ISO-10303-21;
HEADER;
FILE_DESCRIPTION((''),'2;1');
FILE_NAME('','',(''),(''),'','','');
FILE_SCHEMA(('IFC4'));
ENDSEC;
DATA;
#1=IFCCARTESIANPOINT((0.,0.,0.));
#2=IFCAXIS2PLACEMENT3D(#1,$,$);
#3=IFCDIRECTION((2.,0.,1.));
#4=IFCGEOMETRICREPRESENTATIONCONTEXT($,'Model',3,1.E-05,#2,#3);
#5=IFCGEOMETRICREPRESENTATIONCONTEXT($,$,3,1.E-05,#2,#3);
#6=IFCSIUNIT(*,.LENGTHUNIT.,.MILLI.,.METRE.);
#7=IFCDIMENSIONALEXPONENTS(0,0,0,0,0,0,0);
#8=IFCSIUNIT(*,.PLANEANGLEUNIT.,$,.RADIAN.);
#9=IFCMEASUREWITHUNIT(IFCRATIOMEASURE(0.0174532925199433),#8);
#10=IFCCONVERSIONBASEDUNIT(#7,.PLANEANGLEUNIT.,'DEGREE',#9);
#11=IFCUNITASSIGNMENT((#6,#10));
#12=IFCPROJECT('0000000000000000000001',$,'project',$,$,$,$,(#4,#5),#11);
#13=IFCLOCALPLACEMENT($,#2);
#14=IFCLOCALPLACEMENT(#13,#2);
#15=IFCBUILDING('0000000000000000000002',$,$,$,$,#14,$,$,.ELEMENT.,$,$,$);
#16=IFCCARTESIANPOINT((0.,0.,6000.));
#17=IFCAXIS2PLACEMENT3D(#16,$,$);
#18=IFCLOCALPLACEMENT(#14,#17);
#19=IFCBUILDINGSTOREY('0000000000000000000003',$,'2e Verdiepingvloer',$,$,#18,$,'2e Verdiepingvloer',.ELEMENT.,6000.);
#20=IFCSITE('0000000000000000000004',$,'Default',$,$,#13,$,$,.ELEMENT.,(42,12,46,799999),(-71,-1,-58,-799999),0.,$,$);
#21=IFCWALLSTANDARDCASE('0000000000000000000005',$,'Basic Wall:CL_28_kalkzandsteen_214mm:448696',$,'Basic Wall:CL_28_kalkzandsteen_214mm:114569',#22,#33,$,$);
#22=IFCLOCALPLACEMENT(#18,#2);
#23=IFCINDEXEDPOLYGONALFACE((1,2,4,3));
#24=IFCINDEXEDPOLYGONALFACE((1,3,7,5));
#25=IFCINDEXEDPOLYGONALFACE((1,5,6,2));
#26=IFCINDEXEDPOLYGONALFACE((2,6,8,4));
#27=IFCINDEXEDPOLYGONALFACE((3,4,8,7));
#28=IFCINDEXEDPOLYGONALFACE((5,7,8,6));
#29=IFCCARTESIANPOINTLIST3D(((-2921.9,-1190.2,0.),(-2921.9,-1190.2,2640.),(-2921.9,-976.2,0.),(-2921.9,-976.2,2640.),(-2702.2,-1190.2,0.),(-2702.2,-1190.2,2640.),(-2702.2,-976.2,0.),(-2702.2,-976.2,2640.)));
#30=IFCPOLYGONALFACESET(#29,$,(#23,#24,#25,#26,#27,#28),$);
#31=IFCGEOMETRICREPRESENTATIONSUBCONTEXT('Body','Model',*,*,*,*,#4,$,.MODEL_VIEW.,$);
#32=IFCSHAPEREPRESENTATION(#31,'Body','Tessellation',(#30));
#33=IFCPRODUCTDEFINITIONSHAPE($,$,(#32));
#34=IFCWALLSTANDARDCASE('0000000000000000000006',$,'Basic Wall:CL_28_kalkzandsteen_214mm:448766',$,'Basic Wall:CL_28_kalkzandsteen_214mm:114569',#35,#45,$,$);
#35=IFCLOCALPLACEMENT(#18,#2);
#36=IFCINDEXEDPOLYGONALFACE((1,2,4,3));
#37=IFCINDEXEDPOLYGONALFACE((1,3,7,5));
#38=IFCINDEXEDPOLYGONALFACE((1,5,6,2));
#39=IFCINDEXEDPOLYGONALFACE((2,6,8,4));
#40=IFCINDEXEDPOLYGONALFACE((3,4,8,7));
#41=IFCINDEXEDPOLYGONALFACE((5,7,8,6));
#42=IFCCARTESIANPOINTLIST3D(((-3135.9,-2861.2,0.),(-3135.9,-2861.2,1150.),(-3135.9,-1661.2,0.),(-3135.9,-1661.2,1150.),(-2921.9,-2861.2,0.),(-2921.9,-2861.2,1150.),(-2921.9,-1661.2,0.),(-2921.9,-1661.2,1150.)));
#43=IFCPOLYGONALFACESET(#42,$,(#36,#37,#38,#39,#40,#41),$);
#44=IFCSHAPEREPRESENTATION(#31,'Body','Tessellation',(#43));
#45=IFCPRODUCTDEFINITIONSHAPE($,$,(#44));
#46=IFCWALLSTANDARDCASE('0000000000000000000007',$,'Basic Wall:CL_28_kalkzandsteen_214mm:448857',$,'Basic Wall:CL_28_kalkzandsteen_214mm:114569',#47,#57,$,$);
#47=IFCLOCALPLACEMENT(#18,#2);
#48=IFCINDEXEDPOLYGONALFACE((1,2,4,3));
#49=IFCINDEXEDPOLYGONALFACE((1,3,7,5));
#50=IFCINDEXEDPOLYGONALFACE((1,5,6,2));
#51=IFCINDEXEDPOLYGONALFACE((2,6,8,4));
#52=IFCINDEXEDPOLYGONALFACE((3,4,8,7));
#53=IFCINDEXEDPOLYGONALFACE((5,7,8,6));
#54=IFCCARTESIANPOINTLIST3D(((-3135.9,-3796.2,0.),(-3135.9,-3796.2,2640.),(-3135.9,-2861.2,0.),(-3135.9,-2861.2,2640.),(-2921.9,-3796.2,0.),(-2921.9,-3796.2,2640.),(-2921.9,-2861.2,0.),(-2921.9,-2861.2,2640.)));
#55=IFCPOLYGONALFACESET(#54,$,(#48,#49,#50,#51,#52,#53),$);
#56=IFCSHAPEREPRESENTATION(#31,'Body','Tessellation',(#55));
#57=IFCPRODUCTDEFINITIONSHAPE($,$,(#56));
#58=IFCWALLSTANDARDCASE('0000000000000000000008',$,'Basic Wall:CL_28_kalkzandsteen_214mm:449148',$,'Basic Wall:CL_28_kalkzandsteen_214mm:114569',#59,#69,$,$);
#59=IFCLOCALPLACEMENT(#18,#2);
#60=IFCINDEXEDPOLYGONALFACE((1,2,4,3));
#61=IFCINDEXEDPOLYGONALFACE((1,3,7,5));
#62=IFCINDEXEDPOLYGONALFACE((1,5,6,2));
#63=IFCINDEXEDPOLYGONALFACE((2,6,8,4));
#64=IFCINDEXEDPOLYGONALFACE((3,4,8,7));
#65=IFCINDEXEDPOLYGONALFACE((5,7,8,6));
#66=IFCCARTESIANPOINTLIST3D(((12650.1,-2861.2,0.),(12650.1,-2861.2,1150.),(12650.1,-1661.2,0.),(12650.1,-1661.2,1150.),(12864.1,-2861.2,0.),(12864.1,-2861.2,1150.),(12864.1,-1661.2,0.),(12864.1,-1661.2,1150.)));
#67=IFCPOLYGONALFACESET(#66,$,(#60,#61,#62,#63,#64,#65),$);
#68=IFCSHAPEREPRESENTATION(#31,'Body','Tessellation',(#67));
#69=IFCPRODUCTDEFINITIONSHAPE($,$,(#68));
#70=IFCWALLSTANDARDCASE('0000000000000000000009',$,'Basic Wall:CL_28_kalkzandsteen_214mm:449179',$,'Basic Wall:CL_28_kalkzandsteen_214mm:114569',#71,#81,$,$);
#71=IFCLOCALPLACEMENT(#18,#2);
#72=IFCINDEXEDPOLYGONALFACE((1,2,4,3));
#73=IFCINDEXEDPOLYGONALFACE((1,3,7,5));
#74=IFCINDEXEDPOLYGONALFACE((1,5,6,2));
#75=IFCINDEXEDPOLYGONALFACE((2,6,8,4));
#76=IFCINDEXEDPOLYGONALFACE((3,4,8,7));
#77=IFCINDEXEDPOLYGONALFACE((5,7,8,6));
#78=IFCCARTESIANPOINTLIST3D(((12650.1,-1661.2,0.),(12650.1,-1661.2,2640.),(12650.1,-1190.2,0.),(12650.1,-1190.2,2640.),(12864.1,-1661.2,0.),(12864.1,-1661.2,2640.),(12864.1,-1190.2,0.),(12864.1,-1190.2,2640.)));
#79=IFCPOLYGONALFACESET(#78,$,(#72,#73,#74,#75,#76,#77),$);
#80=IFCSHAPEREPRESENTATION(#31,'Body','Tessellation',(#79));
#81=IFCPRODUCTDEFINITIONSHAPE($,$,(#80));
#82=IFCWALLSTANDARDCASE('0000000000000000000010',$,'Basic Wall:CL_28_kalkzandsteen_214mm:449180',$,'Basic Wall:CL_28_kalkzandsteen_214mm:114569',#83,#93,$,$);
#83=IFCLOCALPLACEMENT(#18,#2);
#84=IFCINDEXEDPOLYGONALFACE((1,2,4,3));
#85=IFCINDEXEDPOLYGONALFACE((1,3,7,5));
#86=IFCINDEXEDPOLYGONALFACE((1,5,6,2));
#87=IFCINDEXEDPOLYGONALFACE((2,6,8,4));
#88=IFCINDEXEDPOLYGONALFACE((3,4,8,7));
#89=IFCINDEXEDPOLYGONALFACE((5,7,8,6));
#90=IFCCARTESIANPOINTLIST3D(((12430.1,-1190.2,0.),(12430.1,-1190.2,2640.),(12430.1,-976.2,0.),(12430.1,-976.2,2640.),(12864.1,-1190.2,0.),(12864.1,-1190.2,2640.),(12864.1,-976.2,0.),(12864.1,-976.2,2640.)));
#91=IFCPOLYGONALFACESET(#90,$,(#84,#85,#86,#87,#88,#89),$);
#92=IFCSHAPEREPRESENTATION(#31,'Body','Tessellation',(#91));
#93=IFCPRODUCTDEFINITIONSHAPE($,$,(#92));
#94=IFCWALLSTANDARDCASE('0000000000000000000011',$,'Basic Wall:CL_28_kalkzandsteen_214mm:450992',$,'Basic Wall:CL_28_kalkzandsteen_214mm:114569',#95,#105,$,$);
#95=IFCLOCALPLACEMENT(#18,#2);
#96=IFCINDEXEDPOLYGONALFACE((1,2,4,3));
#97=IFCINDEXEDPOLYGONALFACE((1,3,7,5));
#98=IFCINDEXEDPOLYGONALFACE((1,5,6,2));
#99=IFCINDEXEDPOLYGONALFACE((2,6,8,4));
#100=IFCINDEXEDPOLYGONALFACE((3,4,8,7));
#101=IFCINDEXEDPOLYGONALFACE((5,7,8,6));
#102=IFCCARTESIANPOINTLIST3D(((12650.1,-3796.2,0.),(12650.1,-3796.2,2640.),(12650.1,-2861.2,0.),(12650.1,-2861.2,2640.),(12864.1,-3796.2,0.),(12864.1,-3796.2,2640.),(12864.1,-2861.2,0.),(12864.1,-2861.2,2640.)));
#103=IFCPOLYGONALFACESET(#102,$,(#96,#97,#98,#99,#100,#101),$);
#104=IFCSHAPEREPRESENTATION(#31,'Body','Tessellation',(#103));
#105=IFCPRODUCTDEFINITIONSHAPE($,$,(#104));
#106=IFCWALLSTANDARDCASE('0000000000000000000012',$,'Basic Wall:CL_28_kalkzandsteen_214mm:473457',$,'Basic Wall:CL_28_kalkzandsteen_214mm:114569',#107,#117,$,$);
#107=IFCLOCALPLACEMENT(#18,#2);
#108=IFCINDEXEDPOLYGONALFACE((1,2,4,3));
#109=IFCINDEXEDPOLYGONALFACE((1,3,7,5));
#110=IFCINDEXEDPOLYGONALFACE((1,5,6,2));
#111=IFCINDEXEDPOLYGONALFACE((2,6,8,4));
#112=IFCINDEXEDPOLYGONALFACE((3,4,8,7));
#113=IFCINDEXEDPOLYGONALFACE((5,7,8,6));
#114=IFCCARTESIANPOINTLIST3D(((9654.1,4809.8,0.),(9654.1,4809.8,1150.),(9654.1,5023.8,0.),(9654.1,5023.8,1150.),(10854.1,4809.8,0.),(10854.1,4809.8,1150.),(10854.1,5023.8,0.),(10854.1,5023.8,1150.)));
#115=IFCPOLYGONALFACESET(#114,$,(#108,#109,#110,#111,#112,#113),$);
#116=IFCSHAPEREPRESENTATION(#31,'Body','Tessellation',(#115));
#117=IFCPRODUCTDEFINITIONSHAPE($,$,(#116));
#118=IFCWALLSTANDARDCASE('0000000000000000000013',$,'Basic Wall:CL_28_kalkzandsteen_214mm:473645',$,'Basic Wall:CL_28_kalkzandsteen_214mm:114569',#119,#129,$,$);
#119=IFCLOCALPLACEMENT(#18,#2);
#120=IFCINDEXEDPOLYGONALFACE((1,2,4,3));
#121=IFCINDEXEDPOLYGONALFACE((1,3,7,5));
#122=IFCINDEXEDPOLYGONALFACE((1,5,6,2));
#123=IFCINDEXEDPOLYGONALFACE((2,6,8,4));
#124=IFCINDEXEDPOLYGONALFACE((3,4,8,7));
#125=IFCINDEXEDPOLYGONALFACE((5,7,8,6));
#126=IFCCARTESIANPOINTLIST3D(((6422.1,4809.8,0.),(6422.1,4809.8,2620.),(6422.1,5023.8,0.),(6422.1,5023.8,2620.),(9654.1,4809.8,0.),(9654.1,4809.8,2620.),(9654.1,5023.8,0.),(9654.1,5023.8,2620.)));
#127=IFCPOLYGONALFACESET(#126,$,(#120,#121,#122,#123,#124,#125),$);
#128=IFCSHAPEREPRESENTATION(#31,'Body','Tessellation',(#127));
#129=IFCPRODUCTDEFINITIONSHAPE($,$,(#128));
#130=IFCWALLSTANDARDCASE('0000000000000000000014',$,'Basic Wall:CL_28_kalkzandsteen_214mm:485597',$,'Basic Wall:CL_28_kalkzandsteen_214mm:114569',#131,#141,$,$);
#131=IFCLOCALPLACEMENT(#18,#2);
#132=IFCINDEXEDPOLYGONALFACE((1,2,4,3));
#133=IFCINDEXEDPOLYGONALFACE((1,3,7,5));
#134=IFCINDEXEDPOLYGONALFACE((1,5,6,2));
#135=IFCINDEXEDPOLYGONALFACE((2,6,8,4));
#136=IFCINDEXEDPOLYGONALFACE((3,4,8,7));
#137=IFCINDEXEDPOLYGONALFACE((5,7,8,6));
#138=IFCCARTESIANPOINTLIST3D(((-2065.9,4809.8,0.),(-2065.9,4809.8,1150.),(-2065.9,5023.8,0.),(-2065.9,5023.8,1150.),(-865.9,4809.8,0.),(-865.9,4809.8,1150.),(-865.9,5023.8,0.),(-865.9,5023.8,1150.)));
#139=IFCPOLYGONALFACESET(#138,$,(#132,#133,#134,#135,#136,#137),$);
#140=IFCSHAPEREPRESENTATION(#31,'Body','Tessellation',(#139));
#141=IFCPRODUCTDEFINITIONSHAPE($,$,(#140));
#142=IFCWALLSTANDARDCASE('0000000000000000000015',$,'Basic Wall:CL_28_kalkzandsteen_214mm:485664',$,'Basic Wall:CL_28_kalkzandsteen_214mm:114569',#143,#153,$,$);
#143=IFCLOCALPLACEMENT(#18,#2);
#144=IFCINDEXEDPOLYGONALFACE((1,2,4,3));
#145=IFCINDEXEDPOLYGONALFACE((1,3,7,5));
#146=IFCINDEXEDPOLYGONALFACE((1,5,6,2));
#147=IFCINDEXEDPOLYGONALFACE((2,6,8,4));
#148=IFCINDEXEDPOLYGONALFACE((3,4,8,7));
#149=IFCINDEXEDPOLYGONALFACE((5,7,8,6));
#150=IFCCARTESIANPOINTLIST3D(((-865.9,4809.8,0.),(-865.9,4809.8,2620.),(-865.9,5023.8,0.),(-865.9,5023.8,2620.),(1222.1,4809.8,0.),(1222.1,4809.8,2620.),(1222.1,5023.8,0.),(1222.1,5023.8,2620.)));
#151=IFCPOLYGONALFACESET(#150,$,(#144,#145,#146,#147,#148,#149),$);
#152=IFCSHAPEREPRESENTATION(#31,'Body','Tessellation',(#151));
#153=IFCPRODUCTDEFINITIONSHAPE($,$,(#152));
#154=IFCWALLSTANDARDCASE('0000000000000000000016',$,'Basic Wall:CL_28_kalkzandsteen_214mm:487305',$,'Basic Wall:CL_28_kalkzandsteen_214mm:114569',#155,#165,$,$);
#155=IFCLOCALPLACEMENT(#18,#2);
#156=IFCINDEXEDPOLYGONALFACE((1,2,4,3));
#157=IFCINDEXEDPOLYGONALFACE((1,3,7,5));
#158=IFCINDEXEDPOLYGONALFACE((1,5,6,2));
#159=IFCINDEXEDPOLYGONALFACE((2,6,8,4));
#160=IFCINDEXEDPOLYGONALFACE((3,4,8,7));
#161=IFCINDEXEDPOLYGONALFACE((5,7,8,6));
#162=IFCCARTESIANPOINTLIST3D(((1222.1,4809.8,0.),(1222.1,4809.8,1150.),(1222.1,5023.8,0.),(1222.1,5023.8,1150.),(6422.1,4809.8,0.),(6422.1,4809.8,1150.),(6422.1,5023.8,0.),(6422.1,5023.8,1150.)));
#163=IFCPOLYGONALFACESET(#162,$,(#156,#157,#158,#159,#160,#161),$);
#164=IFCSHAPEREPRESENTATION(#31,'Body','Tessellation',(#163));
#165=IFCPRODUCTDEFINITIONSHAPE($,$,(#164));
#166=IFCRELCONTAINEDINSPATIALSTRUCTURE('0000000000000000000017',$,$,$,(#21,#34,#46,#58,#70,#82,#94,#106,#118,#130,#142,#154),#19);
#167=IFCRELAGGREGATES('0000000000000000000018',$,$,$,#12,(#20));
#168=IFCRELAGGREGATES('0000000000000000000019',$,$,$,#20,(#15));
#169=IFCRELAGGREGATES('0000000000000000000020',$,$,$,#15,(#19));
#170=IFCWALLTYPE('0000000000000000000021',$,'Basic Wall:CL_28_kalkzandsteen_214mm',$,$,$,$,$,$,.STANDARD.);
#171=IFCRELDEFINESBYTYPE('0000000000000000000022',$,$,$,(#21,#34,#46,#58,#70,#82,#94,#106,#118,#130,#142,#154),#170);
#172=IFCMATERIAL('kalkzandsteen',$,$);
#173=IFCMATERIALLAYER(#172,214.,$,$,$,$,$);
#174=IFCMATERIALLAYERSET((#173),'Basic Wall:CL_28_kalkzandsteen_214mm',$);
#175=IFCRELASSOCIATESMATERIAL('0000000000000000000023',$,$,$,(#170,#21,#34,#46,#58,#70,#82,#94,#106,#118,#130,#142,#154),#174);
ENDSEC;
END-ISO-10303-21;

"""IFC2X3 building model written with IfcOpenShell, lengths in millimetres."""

from ifc_helpers import new_model, entity, si_unit, converted_unit, direction, frame, frame_2d, origin, place, context, subcontext, project, spatial, polyline, rectangle, extrude, clip, bounded_halfspace, material, layer, layer_set, layer_usage, type_object, element, save


model = new_model("IFC2X3")

# Units and contexts
model_context = context("Model", 3, precision=1e-05, world=origin(), true_north=direction((2.0, 0.0, 1.0)))
context_of_model = context(None, 3, precision=1e-05, world=origin(), true_north=direction((2.0, 0.0, 1.0)))
body_context = subcontext(model_context, "Body", "Model", "MODEL_VIEW")
ifc_project = project(units=[si_unit("LENGTHUNIT", "METRE", prefix="MILLI"), converted_unit("PLANEANGLEUNIT", "DEGREE", entity("IfcRatioMeasure", 0.0174532925199433), si_unit("PLANEANGLEUNIT", "RADIAN"), dimensions=[0, 0, 0, 0, 0, 0, 0])], contexts=[model_context, context_of_model])

# Site, building, storey
site_placement = place(None, origin())
site = spatial("IfcSite", under=ifc_project, at=site_placement, Name="Default", CompositionType="ELEMENT", RefLatitude=(42, 12, 46, 799999), RefLongitude=(-71, -1, -58, -799999), RefElevation=0.0)
building_placement = place(site_placement, origin())
building = spatial("IfcBuilding", under=site, at=building_placement, CompositionType="ELEMENT")
storey_placement = place(building_placement, frame((0.0, 0.0, 6000.0)))
storey = spatial("IfcBuildingStorey", under=building, at=storey_placement, Name="2e Verdiepingvloer", LongName="2e Verdiepingvloer", CompositionType="ELEMENT", Elevation=6000.0)

# Walls
ifc_material_1 = material(Name="kalkzandsteen")
ifc_layer_1 = layer(ifc_material_1, 214.0)
ifc_layer_set_1 = layer_set([ifc_layer_1], Name="Basic Wall:CL_28_kalkzandsteen_214mm")
wall_type_1 = type_object("IfcWallType", Name="Basic Wall:CL_28_kalkzandsteen_214mm", PredefinedType="STANDARD", material=ifc_layer_set_1)
ifc_layer_usage_1 = layer_usage(ifc_layer_set_1, "AXIS2", "NEGATIVE", 107.0)
wall_1_placement = place(storey_placement, frame((-2702.2, -1083.2, 0.0), z_axis=(0.0, 0.0, 1.0), x_axis=(-1.0, 0.0, 0.0)))
element("IfcWallStandardCase", 1, at=wall_1_placement, inside=storey, type_object=wall_type_1, material=ifc_layer_usage_1, Name="Basic Wall:CL_28_kalkzandsteen_214mm:448696", ObjectType="Basic Wall:CL_28_kalkzandsteen_214mm:114569", context=body_context, shape_type="SweptSolid", body=[
    extrude(rectangle(XDim=219.7, YDim=214.0, at=frame_2d((109.9, 0.0), x_axis=(-1.0, 0.0))), origin(), (0.0, 0.0, 1.0), 2640.0),
])
ifc_layer_usage_2 = layer_usage(ifc_layer_set_1, "AXIS2", "NEGATIVE", 107.0)
wall_2_placement = place(storey_placement, frame((-3028.9, -1661.2, 0.0), z_axis=(0.0, 0.0, 1.0), x_axis=(0.0, -1.0, 0.0)))
element("IfcWallStandardCase", 2, at=wall_2_placement, inside=storey, type_object=wall_type_1, material=ifc_layer_usage_2, Name="Basic Wall:CL_28_kalkzandsteen_214mm:448766", ObjectType="Basic Wall:CL_28_kalkzandsteen_214mm:114569", context=body_context, shape_type="SweptSolid", body=[
    extrude(rectangle(XDim=1200.0, YDim=214.0, at=frame_2d((600.0, 0.0), x_axis=(-1.0, 0.0))), origin(), (0.0, 0.0, 1.0), 1150.0),
])
ifc_layer_usage_3 = layer_usage(ifc_layer_set_1, "AXIS2", "NEGATIVE", 107.0)
wall_3_placement = place(storey_placement, frame((-3028.9, -2861.2, 0.0), z_axis=(0.0, 0.0, 1.0), x_axis=(0.0, -1.0, 0.0)))
element("IfcWallStandardCase", 3, at=wall_3_placement, inside=storey, type_object=wall_type_1, material=ifc_layer_usage_3, Name="Basic Wall:CL_28_kalkzandsteen_214mm:448857", ObjectType="Basic Wall:CL_28_kalkzandsteen_214mm:114569", context=body_context, shape_type="SweptSolid", body=[
    extrude(rectangle(XDim=935.0, YDim=214.0, at=frame_2d((467.5, 0.0), x_axis=(-1.0, 0.0))), origin(), (0.0, 0.0, 1.0), 2640.0),
])
ifc_layer_usage_4 = layer_usage(ifc_layer_set_1, "AXIS2", "NEGATIVE", 107.0)
wall_4_placement = place(storey_placement, frame((12757.1, -2861.2, 0.0), z_axis=(0.0, 0.0, 1.0), x_axis=(0.0, 1.0, 0.0)))
element("IfcWallStandardCase", 4, at=wall_4_placement, inside=storey, type_object=wall_type_1, material=ifc_layer_usage_4, Name="Basic Wall:CL_28_kalkzandsteen_214mm:449148", ObjectType="Basic Wall:CL_28_kalkzandsteen_214mm:114569", context=body_context, shape_type="SweptSolid", body=[
    extrude(rectangle(XDim=1200.0, YDim=214.0, at=frame_2d((600.0, 0.0), x_axis=(-1.0, 0.0))), origin(), (0.0, 0.0, 1.0), 1150.0),
])
ifc_layer_usage_5 = layer_usage(ifc_layer_set_1, "AXIS2", "NEGATIVE", 107.0)
wall_5_placement = place(storey_placement, frame((12757.1, -1661.2, 0.0), z_axis=(0.0, 0.0, 1.0), x_axis=(0.0, 1.0, 0.0)))
element("IfcWallStandardCase", 5, at=wall_5_placement, inside=storey, type_object=wall_type_1, material=ifc_layer_usage_5, Name="Basic Wall:CL_28_kalkzandsteen_214mm:449179", ObjectType="Basic Wall:CL_28_kalkzandsteen_214mm:114569", context=body_context, shape_type="SweptSolid", body=[
    extrude(rectangle(XDim=471.0, YDim=214.0, at=frame_2d((235.5, 0.0), x_axis=(-1.0, 0.0))), origin(), (0.0, 0.0, 1.0), 2640.0),
])
ifc_layer_usage_6 = layer_usage(ifc_layer_set_1, "AXIS2", "NEGATIVE", 107.0)
wall_6_placement = place(storey_placement, frame((12864.1, -1083.2, 0.0), z_axis=(0.0, 0.0, 1.0), x_axis=(-1.0, 0.0, 0.0)))
element("IfcWallStandardCase", 6, at=wall_6_placement, inside=storey, type_object=wall_type_1, material=ifc_layer_usage_6, Name="Basic Wall:CL_28_kalkzandsteen_214mm:449180", ObjectType="Basic Wall:CL_28_kalkzandsteen_214mm:114569", context=body_context, shape_type="SweptSolid", body=[
    extrude(rectangle(XDim=434.0, YDim=214.0, at=frame_2d((217.0, 0.0), x_axis=(-1.0, 0.0))), origin(), (0.0, 0.0, 1.0), 2640.0),
])
ifc_layer_usage_7 = layer_usage(ifc_layer_set_1, "AXIS2", "NEGATIVE", 107.0)
wall_7_placement = place(storey_placement, frame((12757.1, -3796.2, 0.0), z_axis=(0.0, 0.0, 1.0), x_axis=(0.0, 1.0, 0.0)))
element("IfcWallStandardCase", 7, at=wall_7_placement, inside=storey, type_object=wall_type_1, material=ifc_layer_usage_7, Name="Basic Wall:CL_28_kalkzandsteen_214mm:450992", ObjectType="Basic Wall:CL_28_kalkzandsteen_214mm:114569", context=body_context, shape_type="SweptSolid", body=[
    extrude(rectangle(XDim=935.0, YDim=214.0, at=frame_2d((467.5, 0.0), x_axis=(-1.0, 0.0))), origin(), (0.0, 0.0, 1.0), 2640.0),
])
ifc_layer_usage_8 = layer_usage(ifc_layer_set_1, "AXIS2", "NEGATIVE", 107.0)
wall_8_placement = place(storey_placement, frame((10854.1, 4916.8, 0.0), z_axis=(0.0, 0.0, 1.0), x_axis=(-1.0, 0.0, 0.0)))
element("IfcWallStandardCase", 8, at=wall_8_placement, inside=storey, type_object=wall_type_1, material=ifc_layer_usage_8, Name="Basic Wall:CL_28_kalkzandsteen_214mm:473457", ObjectType="Basic Wall:CL_28_kalkzandsteen_214mm:114569", context=body_context, shape_type="SweptSolid", body=[
    extrude(rectangle(XDim=1200.0, YDim=214.0, at=frame_2d((600.0, 0.0), x_axis=(-1.0, 0.0))), origin(), (0.0, 0.0, 1.0), 1150.0),
])
ifc_layer_usage_9 = layer_usage(ifc_layer_set_1, "AXIS2", "NEGATIVE", 107.0)
wall_9_placement = place(storey_placement, frame((9654.1, 4916.8, 0.0), z_axis=(0.0, 0.0, 1.0), x_axis=(-1.0, 0.0, 0.0)))
element("IfcWallStandardCase", 9, at=wall_9_placement, inside=storey, type_object=wall_type_1, material=ifc_layer_usage_9, Name="Basic Wall:CL_28_kalkzandsteen_214mm:473645", ObjectType="Basic Wall:CL_28_kalkzandsteen_214mm:114569", context=body_context, shape_type="Clipping", body=[
    clip(extrude(rectangle(XDim=3232.0, YDim=214.0, at=frame_2d((1616.0, 0.0), x_axis=(-1.0, 0.0))), origin(), (0.0, 0.0, 1.0), 2620.0), bounded_halfspace(frame((0.0, -107.0, 2620.0), z_axis=(0.0, 0.0, -1.0), x_axis=(-1.0, 0.0, 0.0)), True, frame((0.0, -107.0, 2620.0)), polyline([(0.0, 0.0), (3232.0, 0.0), (3232.0, 214.0), (0.0, 214.0), (0.0, 0.0)]))),
])
ifc_layer_usage_10 = layer_usage(ifc_layer_set_1, "AXIS2", "NEGATIVE", 107.0)
wall_10_placement = place(storey_placement, frame((-865.9, 4916.8, 0.0), z_axis=(0.0, 0.0, 1.0), x_axis=(-1.0, 0.0, 0.0)))
element("IfcWallStandardCase", 10, at=wall_10_placement, inside=storey, type_object=wall_type_1, material=ifc_layer_usage_10, Name="Basic Wall:CL_28_kalkzandsteen_214mm:485597", ObjectType="Basic Wall:CL_28_kalkzandsteen_214mm:114569", context=body_context, shape_type="SweptSolid", body=[
    extrude(rectangle(XDim=1200.0, YDim=214.0, at=frame_2d((600.0, 0.0), x_axis=(-1.0, 0.0))), origin(), (0.0, 0.0, 1.0), 1150.0),
])
ifc_layer_usage_11 = layer_usage(ifc_layer_set_1, "AXIS2", "NEGATIVE", 107.0)
wall_11_placement = place(storey_placement, frame((1222.1, 4916.8, 0.0), z_axis=(0.0, 0.0, 1.0), x_axis=(-1.0, 0.0, 0.0)))
element("IfcWallStandardCase", 11, at=wall_11_placement, inside=storey, type_object=wall_type_1, material=ifc_layer_usage_11, Name="Basic Wall:CL_28_kalkzandsteen_214mm:485664", ObjectType="Basic Wall:CL_28_kalkzandsteen_214mm:114569", context=body_context, shape_type="Clipping", body=[
    clip(extrude(rectangle(XDim=2088.0, YDim=214.0, at=frame_2d((1044.0, 0.0), x_axis=(-1.0, 0.0))), origin(), (0.0, 0.0, 1.0), 2620.0), bounded_halfspace(frame((0.0, -107.0, 2620.0), z_axis=(0.0, 0.0, -1.0), x_axis=(-1.0, 0.0, 0.0)), True, frame((0.0, -107.0, 2620.0)), polyline([(0.0, 0.0), (2088.0, 0.0), (2088.0, 214.0), (1144.0, 214.0), (0.0, 214.0), (0.0, 0.0)]))),
])
ifc_layer_usage_12 = layer_usage(ifc_layer_set_1, "AXIS2", "NEGATIVE", 107.0)
wall_12_placement = place(storey_placement, frame((6422.1, 4916.8, 0.0), z_axis=(0.0, 0.0, 1.0), x_axis=(-1.0, 0.0, 0.0)))
element("IfcWallStandardCase", 12, at=wall_12_placement, inside=storey, type_object=wall_type_1, material=ifc_layer_usage_12, Name="Basic Wall:CL_28_kalkzandsteen_214mm:487305", ObjectType="Basic Wall:CL_28_kalkzandsteen_214mm:114569", context=body_context, shape_type="SweptSolid", body=[
    extrude(rectangle(XDim=5200.0, YDim=214.0, at=frame_2d((2600.0, 0.0), x_axis=(-1.0, 0.0))), origin(), (0.0, 0.0, 1.0), 1150.0),
])

save(model, "model.ifc")
